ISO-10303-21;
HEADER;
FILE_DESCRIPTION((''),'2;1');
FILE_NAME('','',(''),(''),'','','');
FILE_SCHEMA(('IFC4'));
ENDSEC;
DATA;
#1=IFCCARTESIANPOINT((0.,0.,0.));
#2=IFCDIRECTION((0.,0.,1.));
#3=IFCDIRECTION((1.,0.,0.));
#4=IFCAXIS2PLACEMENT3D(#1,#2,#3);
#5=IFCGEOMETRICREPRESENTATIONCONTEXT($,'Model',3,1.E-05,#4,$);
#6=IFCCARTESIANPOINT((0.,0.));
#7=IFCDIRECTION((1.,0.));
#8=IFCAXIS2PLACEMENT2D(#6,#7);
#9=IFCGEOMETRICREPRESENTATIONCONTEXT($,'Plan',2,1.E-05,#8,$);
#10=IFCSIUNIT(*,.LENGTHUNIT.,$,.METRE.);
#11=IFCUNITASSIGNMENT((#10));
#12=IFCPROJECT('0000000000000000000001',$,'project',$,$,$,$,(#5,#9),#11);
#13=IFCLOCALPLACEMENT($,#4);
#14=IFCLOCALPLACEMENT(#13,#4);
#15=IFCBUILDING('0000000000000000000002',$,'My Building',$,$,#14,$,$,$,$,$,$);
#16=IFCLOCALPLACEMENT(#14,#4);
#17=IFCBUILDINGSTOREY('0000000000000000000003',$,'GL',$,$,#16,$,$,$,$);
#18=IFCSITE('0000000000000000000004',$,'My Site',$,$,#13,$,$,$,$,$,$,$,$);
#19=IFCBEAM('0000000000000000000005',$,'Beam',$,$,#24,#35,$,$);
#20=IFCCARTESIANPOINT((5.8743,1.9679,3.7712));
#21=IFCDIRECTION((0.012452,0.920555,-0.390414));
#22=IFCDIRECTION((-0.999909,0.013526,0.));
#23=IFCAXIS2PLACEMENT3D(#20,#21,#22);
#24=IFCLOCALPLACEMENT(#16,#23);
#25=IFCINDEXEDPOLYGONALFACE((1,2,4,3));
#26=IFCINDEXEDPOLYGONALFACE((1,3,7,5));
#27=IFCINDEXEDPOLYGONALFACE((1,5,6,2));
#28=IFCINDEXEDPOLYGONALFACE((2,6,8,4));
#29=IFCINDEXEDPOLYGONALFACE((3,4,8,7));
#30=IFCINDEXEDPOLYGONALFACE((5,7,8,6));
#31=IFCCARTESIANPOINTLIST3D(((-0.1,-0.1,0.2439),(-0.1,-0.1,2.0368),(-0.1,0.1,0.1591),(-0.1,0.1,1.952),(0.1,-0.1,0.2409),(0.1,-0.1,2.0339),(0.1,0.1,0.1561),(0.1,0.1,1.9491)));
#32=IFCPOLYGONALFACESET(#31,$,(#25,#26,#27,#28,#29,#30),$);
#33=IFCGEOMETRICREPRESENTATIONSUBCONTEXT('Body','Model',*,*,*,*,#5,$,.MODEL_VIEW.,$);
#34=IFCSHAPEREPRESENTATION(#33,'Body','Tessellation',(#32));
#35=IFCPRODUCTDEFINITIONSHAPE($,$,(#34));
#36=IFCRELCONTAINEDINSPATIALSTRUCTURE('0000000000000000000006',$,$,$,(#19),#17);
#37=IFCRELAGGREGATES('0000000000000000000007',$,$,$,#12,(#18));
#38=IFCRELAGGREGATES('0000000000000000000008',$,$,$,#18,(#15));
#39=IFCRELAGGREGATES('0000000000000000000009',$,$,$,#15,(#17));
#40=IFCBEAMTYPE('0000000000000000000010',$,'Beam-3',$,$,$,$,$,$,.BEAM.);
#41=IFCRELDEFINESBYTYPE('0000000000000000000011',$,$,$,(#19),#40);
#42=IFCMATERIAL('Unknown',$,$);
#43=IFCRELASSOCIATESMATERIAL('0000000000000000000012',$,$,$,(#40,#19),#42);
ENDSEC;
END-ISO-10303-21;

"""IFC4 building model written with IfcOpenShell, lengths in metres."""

from ifc_helpers import new_model, si_unit, frame, origin_with_axes, origin_2d_with_axis, place, context, subcontext, project, spatial, rectangle, extrude, clip, halfspace, material, material_profile, profile_set, profile_usage, type_object, element, save


model = new_model("IFC4")

# Units and contexts
model_context = context("Model", 3, precision=1e-05, world=origin_with_axes())
plan_context = context("Plan", 2, precision=1e-05, world=origin_2d_with_axis())
body_context = subcontext(model_context, "Body", "Model", "MODEL_VIEW")
ifc_project = project(units=[si_unit("LENGTHUNIT", "METRE")], contexts=[model_context, plan_context])

# Site, building, storey
site_placement = place(None, origin_with_axes())
site = spatial("IfcSite", under=ifc_project, at=site_placement, Name="My Site")
building_placement = place(site_placement, origin_with_axes())
building = spatial("IfcBuilding", under=site, at=building_placement, Name="My Building")
storey_placement = place(building_placement, origin_with_axes())
storey = spatial("IfcBuildingStorey", under=building, at=storey_placement, Name="GL")

# Shared definitions
ifc_material = material(Name="Unknown")

# Beam
ifc_material_profile_1 = material_profile(ifc_material, rectangle(XDim=0.2, YDim=0.2))
ifc_profile_set_1 = profile_set([ifc_material_profile_1])
beam_type_1 = type_object("IfcBeamType", Name="Beam-3", PredefinedType="BEAM", material=ifc_profile_set_1)
ifc_profile_usage_1 = profile_usage(ifc_profile_set_1, cardinal=5)
beam_1_placement = place(storey_placement, frame((5.8743, 1.9679, 3.7712), z_axis=(0.012452, 0.920555, -0.390414), x_axis=(-0.999909, 0.013526, 0.0)))
element("IfcBeam", 1, at=beam_1_placement, inside=storey, type_object=beam_type_1, material=ifc_profile_usage_1, Name="Beam", context=body_context, shape_type="Clipping", body=[
    clip(clip(extrude(rectangle(XDim=0.2, YDim=0.2), origin_with_axes(), (0.0, 0.0, 1.0), 2.193), halfspace(frame((0.0, -0.0847, 0.2359), z_axis=(-0.013526, -0.390379, -0.920555), x_axis=(-0.9994, 0.034626, 0.0)), False)), halfspace(frame((0.0, 0.0995, 1.9508), z_axis=(0.013526, 0.390379, 0.920555), x_axis=(0.9994, -0.034626, 0.0)), False)),
])

save(model, "model.ifc")
